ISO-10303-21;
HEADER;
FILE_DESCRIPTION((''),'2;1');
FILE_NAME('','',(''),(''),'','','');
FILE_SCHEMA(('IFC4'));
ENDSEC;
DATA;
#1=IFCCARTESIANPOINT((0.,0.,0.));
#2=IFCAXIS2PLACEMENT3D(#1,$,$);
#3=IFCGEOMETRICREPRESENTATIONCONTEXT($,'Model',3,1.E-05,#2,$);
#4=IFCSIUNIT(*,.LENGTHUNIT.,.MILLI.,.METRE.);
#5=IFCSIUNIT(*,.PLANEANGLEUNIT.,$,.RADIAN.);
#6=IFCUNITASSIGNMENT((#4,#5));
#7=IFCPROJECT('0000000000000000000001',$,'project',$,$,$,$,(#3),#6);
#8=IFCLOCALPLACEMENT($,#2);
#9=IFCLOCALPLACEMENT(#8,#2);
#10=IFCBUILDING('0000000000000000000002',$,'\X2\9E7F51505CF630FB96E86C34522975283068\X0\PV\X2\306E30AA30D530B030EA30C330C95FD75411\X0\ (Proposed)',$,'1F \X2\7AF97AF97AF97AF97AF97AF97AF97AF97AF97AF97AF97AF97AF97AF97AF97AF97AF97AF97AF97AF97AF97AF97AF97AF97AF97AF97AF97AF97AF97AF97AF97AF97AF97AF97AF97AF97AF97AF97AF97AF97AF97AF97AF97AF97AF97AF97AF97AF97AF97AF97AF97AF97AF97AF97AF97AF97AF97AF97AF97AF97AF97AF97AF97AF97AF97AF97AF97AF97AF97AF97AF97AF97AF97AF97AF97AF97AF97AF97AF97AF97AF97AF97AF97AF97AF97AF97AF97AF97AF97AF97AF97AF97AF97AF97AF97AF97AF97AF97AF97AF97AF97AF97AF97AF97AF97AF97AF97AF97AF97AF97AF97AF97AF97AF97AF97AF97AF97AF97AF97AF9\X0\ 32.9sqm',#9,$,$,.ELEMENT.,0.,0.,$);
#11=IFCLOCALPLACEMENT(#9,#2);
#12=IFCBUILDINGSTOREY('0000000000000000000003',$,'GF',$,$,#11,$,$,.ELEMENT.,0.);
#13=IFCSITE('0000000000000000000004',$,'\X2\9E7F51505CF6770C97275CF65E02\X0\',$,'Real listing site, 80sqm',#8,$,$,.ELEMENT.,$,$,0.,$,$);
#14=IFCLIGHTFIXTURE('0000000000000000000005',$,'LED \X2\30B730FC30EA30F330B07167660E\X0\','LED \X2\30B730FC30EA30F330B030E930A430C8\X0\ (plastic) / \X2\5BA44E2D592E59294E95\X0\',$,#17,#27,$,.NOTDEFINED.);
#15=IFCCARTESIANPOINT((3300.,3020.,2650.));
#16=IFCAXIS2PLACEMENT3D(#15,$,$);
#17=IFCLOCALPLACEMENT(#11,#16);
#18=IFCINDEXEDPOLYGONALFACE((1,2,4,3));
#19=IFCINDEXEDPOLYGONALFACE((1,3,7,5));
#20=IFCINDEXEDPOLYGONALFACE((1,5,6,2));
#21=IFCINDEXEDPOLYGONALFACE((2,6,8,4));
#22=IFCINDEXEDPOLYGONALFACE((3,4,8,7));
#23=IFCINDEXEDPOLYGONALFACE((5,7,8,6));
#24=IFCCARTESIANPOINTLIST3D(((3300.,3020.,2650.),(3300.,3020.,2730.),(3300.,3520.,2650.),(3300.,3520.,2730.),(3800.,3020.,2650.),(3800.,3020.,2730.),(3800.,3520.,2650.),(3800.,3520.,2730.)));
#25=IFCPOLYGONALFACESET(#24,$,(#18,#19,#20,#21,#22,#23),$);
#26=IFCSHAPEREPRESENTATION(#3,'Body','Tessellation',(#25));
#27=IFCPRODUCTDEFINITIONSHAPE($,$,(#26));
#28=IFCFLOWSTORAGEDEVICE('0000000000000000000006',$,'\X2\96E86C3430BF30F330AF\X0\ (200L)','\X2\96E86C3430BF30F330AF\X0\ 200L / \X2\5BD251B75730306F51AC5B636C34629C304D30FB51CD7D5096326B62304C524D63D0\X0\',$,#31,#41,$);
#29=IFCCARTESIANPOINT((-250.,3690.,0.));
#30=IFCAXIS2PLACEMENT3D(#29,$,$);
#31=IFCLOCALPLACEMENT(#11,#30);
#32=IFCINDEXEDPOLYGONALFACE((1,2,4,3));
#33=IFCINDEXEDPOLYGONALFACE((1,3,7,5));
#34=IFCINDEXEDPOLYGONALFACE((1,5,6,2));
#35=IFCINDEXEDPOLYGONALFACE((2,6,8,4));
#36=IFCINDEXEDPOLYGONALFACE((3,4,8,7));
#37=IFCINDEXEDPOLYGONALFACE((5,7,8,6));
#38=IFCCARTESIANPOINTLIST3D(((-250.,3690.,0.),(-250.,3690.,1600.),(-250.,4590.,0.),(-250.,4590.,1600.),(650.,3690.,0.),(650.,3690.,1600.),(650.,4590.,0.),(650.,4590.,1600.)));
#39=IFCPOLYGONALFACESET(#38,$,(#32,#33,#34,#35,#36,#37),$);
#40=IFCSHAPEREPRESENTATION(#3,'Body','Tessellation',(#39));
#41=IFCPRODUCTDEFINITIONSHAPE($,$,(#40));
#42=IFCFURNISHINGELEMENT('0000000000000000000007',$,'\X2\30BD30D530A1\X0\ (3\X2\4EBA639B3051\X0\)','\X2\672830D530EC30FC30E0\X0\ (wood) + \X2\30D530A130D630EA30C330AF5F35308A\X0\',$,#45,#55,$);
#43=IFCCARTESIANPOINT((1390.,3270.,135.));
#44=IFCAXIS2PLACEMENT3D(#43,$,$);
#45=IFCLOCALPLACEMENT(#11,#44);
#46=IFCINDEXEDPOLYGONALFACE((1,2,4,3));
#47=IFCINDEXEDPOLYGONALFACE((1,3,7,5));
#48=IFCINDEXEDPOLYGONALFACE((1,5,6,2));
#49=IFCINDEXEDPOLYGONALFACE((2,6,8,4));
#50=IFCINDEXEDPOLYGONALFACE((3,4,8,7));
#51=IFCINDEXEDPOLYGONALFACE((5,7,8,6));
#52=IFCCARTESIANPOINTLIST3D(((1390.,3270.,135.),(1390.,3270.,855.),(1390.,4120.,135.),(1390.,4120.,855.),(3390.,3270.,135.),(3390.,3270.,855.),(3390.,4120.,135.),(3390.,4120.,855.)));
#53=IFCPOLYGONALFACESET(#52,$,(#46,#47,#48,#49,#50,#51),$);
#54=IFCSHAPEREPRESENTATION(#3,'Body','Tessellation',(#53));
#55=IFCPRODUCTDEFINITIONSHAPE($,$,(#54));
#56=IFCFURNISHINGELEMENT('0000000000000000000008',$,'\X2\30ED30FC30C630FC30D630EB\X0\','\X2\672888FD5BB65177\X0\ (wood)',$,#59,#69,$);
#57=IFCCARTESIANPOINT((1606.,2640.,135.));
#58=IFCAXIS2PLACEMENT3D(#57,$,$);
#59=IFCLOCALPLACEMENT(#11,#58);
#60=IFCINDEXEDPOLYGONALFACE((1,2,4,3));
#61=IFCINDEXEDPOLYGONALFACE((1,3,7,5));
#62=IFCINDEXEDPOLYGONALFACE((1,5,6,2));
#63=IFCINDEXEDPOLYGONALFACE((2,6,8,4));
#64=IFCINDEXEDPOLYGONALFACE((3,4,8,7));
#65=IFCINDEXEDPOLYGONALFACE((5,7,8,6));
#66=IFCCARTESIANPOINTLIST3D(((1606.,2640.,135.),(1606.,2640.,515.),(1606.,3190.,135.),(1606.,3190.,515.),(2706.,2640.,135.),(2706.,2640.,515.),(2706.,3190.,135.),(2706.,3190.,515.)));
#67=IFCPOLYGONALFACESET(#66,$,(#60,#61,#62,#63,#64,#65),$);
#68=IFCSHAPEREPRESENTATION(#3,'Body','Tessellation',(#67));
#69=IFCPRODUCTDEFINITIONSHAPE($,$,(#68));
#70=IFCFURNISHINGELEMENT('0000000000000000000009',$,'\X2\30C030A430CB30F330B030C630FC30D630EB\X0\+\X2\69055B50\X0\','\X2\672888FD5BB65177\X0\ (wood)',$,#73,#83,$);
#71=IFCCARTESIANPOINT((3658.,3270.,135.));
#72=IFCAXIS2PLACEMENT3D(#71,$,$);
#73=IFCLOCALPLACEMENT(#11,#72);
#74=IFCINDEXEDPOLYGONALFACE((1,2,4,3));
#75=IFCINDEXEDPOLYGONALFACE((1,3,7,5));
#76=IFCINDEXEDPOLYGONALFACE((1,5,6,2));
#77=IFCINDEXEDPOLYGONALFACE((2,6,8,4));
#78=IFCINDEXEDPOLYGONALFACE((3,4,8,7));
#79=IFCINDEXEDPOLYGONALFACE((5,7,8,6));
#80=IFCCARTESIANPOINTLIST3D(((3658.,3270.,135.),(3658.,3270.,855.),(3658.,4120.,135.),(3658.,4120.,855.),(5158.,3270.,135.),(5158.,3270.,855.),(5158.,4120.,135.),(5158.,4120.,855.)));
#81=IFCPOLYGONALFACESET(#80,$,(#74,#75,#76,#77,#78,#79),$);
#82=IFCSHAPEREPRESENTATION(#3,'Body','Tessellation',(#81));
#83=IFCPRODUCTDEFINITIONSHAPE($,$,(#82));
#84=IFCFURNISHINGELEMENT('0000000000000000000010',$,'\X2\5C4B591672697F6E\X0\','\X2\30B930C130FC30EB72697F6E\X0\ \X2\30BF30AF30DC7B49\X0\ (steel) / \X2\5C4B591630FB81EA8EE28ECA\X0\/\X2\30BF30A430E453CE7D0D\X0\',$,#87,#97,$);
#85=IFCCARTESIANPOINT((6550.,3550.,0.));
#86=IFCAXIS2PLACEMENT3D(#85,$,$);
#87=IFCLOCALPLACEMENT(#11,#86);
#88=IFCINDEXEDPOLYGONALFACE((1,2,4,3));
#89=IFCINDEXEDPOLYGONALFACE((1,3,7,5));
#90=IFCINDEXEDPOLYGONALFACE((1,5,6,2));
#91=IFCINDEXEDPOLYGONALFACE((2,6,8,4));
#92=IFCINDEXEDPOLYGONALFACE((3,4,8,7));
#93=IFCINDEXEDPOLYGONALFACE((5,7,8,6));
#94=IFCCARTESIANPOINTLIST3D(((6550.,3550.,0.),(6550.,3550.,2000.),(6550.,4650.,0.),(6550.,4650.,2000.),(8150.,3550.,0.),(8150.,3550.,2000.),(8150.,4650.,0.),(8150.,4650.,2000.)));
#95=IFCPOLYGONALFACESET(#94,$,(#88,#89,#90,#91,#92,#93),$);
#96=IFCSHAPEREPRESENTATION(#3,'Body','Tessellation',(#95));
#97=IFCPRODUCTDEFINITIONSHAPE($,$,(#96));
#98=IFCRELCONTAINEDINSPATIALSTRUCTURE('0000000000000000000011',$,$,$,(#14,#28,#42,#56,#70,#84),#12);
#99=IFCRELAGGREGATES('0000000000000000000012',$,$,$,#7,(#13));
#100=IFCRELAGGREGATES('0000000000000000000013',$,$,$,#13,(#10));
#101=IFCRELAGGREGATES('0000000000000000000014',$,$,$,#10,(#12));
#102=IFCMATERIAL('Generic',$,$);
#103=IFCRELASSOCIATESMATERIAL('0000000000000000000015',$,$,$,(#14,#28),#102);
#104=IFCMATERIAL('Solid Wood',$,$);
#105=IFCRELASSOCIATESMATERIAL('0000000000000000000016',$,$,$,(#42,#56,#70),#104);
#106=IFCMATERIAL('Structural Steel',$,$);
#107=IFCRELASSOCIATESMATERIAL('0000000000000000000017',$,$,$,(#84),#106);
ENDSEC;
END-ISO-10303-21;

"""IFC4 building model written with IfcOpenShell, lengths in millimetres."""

from ifc_helpers import new_model, si_unit, frame, frame_2d, origin, place, context, project, spatial, rectangle, extrude, material, element, save


model = new_model("IFC4")

# Units and contexts
model_context = context("Model", 3, precision=1e-05, world=origin())
ifc_project = project(units=[si_unit("LENGTHUNIT", "METRE", prefix="MILLI"), si_unit("PLANEANGLEUNIT", "RADIAN")], contexts=[model_context])

# Site, building, storey
site_placement = place(None, origin())
site = spatial("IfcSite", under=ifc_project, at=site_placement, Name="鹿児島県霧島市", ObjectType="Real listing site, 80sqm", CompositionType="ELEMENT", RefElevation=0.0)
building_placement = place(site_placement, origin())
building = spatial("IfcBuilding", under=site, at=building_placement, Name="鹿児島・雨水利用とPVのオフグリッド志向 (Proposed)", ObjectType="1F 竹竹竹竹竹竹竹竹竹竹竹竹竹竹竹竹竹竹竹竹竹竹竹竹竹竹竹竹竹竹竹竹竹竹竹竹竹竹竹竹竹竹竹竹竹竹竹竹竹竹竹竹竹竹竹竹竹竹竹竹竹竹竹竹竹竹竹竹竹竹竹竹竹竹竹竹竹竹竹竹竹竹竹竹竹竹竹竹竹竹竹竹竹竹竹竹竹竹竹竹竹竹竹竹竹竹竹竹竹竹竹竹竹竹竹竹竹竹竹竹 32.9sqm", CompositionType="ELEMENT", ElevationOfRefHeight=0.0, ElevationOfTerrain=0.0)
storey_placement = place(building_placement, origin())
storey = spatial("IfcBuildingStorey", under=building, at=storey_placement, Name="GF", CompositionType="ELEMENT", Elevation=0.0)

# Shared definitions
ifc_material_1 = material(Name="Solid Wood")

# Shared definitions
ifc_material_2 = material(Name="Structural Steel")

# Light fixture
ifc_material_3 = material(Name="Generic")
light_fixture_placement = place(storey_placement, frame((3300.0, 3020.0, 2650.0)))
element("IfcLightFixture", 1, at=light_fixture_placement, inside=storey, material=ifc_material_3, Name="LED シーリング照明", Description="LED シーリングライト (plastic) / 室中央天井", PredefinedType="NOTDEFINED", context=model_context, shape_type="SweptSolid", body=[
    extrude(rectangle(XDim=500.0, YDim=500.0, at=frame_2d((250.0, 250.0))), frame((3300.0, 3020.0, 2650.0)), (0.0, 0.0, 1.0), 80.0),
])

# Flow storage device
flow_storage_device_placement = place(storey_placement, frame((-250.0, 3690.0, 0.0)))
element("IfcFlowStorageDevice", 2, at=flow_storage_device_placement, inside=storey, material=ifc_material_3, Name="雨水タンク (200L)", Description="雨水タンク 200L / 寒冷地は冬季水抜き・凍結防止が前提", context=model_context, shape_type="SweptSolid", body=[
    extrude(rectangle(XDim=900.0, YDim=900.0, at=frame_2d((450.0, 450.0))), frame((-250.0, 3690.0, 0.0)), (0.0, 0.0, 1.0), 1600.0),
])

# Furnishing elements
furnishing_1_placement = place(storey_placement, frame((1390.0, 3270.0, 135.0)))
element("IfcFurnishingElement", 3, at=furnishing_1_placement, inside=storey, material=ifc_material_1, Name="ソファ (3人掛け)", Description="木フレーム (wood) + ファブリック張り", context=model_context, shape_type="SweptSolid", body=[
    extrude(rectangle(XDim=2000.0, YDim=850.0, at=frame_2d((1000.0, 425.0))), frame((1390.0, 3270.0, 135.0)), (0.0, 0.0, 1.0), 720.0),
])
furnishing_2_placement = place(storey_placement, frame((1606.0, 2640.0, 135.0)))
element("IfcFurnishingElement", 4, at=furnishing_2_placement, inside=storey, material=ifc_material_1, Name="ローテーブル", Description="木製家具 (wood)", context=model_context, shape_type="SweptSolid", body=[
    extrude(rectangle(XDim=1100.0, YDim=550.0, at=frame_2d((550.0, 275.0))), frame((1606.0, 2640.0, 135.0)), (0.0, 0.0, 1.0), 380.0),
])
furnishing_3_placement = place(storey_placement, frame((3658.0, 3270.0, 135.0)))
element("IfcFurnishingElement", 5, at=furnishing_3_placement, inside=storey, material=ifc_material_1, Name="ダイニングテーブル+椅子", Description="木製家具 (wood)", context=model_context, shape_type="SweptSolid", body=[
    extrude(rectangle(XDim=1500.0, YDim=850.0, at=frame_2d((750.0, 425.0))), frame((3658.0, 3270.0, 135.0)), (0.0, 0.0, 1.0), 720.0),
])
furnishing_4_placement = place(storey_placement, frame((6550.0, 3550.0, 0.0)))
element("IfcFurnishingElement", 6, at=furnishing_4_placement, inside=storey, material=ifc_material_2, Name="屋外物置", Description="スチール物置 タクボ等 (steel) / 屋外・自転車/タイヤ収納", context=model_context, shape_type="SweptSolid", body=[
    extrude(rectangle(XDim=1600.0, YDim=1100.0, at=frame_2d((800.0, 550.0))), frame((6550.0, 3550.0, 0.0)), (0.0, 0.0, 1.0), 2000.0),
])

save(model, "model.ifc")
